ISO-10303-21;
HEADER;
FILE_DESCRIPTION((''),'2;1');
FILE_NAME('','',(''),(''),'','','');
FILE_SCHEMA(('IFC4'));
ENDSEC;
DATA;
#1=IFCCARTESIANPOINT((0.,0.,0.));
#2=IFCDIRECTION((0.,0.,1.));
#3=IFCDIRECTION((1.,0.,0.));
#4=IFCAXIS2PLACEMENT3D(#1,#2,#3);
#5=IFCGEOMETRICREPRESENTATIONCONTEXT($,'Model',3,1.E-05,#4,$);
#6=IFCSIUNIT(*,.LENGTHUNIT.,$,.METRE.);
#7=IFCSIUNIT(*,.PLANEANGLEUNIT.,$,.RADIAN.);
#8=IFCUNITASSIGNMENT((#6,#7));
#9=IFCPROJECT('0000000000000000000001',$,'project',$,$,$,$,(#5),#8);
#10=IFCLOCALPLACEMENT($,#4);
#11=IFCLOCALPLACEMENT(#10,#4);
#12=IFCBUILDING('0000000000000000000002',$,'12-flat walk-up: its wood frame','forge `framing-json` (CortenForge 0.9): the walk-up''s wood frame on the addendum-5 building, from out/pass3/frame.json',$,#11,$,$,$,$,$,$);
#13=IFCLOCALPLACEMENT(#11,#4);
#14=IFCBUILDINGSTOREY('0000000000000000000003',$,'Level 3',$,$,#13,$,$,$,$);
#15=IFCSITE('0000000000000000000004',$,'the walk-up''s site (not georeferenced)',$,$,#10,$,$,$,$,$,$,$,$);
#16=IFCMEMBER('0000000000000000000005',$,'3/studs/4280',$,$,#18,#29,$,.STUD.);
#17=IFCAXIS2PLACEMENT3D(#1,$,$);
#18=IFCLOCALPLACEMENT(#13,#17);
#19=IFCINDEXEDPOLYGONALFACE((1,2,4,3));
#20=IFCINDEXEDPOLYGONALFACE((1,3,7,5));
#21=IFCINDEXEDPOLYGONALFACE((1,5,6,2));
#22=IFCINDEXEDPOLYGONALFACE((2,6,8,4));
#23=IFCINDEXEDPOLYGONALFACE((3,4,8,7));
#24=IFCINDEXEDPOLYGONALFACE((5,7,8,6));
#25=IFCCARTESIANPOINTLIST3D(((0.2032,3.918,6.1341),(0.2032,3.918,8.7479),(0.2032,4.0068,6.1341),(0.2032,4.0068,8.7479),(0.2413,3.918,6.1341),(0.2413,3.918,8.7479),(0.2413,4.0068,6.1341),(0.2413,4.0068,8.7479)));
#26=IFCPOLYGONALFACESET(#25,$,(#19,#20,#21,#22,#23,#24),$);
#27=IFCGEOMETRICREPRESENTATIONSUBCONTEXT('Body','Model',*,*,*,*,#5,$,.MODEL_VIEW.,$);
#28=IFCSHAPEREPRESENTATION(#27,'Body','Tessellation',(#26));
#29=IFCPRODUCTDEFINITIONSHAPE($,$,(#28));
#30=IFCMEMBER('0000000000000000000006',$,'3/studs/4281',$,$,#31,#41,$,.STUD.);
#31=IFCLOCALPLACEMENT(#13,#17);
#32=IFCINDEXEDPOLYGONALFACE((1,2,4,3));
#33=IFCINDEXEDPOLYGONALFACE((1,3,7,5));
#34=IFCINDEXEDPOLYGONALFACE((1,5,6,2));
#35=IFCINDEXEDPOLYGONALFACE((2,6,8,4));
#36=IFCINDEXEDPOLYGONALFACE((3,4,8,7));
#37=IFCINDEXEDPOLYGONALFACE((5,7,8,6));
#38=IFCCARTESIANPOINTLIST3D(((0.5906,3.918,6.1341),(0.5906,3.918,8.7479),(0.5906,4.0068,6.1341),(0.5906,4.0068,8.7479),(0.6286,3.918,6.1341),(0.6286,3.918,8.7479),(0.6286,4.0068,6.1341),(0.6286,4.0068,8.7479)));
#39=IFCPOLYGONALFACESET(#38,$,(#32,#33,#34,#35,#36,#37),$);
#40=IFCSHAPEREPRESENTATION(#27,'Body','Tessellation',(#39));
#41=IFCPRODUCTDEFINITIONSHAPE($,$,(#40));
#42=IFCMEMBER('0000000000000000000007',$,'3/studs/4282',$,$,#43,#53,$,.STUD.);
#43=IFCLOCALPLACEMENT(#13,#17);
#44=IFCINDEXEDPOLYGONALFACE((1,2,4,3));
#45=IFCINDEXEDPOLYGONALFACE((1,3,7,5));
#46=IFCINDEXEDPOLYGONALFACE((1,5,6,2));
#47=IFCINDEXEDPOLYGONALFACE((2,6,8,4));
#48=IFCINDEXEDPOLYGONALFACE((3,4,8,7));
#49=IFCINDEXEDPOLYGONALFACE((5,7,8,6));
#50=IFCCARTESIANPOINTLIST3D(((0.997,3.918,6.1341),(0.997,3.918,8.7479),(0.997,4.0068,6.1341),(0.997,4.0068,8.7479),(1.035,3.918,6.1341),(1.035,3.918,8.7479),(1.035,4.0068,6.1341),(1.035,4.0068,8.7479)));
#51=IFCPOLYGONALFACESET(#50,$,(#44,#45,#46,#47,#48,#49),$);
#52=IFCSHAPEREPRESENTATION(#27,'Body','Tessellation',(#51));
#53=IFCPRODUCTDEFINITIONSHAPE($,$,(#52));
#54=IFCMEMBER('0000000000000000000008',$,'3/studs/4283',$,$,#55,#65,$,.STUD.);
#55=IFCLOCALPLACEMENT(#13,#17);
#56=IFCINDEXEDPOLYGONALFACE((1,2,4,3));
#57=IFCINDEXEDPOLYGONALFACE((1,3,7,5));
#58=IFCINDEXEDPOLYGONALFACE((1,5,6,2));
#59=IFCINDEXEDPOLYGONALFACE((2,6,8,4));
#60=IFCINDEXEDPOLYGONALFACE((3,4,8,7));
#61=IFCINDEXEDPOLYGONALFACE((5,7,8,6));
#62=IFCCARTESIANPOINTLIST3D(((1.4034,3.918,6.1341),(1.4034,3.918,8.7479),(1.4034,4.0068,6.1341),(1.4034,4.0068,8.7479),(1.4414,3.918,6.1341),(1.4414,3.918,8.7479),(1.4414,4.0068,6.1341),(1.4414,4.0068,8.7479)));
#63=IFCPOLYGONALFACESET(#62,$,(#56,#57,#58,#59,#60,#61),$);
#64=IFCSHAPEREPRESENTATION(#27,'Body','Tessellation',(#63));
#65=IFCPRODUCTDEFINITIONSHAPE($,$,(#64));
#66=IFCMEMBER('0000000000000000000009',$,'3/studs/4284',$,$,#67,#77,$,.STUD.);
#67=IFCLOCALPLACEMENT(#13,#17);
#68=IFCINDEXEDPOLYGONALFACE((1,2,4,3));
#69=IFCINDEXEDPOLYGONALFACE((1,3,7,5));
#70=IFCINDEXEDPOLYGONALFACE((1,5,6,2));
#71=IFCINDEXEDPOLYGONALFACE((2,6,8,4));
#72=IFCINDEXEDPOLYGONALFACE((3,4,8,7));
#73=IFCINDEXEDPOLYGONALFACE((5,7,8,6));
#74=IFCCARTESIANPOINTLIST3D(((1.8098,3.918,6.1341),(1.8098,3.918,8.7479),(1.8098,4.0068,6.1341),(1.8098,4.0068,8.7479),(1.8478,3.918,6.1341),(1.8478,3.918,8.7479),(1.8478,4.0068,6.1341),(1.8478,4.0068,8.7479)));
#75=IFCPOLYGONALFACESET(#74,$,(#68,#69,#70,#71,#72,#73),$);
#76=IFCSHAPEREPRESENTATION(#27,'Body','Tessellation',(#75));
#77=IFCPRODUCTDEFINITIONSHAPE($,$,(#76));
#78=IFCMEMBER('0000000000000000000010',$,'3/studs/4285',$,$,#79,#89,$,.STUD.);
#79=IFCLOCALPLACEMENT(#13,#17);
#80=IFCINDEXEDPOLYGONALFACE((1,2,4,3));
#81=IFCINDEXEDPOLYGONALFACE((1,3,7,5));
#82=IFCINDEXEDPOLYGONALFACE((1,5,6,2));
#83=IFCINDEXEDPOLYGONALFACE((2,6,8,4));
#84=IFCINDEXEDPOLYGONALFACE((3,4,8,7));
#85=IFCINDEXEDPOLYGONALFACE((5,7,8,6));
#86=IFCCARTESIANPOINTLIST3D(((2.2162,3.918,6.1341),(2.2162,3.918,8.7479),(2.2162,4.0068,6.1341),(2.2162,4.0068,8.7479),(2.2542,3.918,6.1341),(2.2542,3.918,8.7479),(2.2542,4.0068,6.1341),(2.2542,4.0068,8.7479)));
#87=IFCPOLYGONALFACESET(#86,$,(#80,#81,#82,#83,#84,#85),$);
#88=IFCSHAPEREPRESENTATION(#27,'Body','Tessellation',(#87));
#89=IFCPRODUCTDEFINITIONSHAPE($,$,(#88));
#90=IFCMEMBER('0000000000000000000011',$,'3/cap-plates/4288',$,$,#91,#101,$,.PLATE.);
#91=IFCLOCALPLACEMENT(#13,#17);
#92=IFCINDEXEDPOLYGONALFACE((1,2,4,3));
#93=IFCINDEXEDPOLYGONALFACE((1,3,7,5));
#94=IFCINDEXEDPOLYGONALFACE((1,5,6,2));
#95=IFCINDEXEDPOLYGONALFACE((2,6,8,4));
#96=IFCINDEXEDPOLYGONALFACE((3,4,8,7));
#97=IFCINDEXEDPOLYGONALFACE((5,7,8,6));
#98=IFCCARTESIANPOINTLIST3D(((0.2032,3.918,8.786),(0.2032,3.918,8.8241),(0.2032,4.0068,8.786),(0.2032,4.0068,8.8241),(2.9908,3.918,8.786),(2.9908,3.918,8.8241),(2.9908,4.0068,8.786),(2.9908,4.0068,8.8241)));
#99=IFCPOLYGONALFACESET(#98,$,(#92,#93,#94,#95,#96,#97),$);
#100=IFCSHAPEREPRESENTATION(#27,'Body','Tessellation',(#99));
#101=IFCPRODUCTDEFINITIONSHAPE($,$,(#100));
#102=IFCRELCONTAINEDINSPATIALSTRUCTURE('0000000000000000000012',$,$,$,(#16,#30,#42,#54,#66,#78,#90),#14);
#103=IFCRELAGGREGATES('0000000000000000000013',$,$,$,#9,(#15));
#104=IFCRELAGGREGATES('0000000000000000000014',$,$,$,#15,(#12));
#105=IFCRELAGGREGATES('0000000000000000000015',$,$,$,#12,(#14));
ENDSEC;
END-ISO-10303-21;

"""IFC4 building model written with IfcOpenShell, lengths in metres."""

from ifc_helpers import new_model, si_unit, frame, frame_2d, origin, origin_with_axes, place, context, subcontext, project, spatial, rectangle, extrude, element, save


model = new_model("IFC4")

# Units and contexts
model_context = context("Model", 3, precision=1e-05, world=origin_with_axes())
body_context = subcontext(model_context, "Body", "Model", "MODEL_VIEW")
ifc_project = project(units=[si_unit("LENGTHUNIT", "METRE"), si_unit("PLANEANGLEUNIT", "RADIAN")], contexts=[model_context])

# Site, building, storey
site_placement = place(None, origin_with_axes())
site = spatial("IfcSite", under=ifc_project, at=site_placement, Name="the walk-up's site (not georeferenced)")
building_placement = place(site_placement, origin_with_axes())
building = spatial("IfcBuilding", under=site, at=building_placement, Name="12-flat walk-up: its wood frame", Description="forge `framing-json` (CortenForge 0.9): the walk-up's wood frame on the addendum-5 building, from out/pass3/frame.json")
storey_placement = place(building_placement, origin_with_axes())
storey = spatial("IfcBuildingStorey", under=building, at=storey_placement, Name="Level 3")

# Members
member_1_placement = place(storey_placement, frame((0.2032, 3.9179, 6.1341), z_axis=(0.0, 0.0, 1.0), x_axis=(1.0, 0.0, 0.0)))
element("IfcMember", 1, at=member_1_placement, inside=storey, Name="3/studs/4280", PredefinedType="STUD", context=body_context, shape_type="SweptSolid", body=[
    extrude(rectangle(XDim=0.0381, YDim=0.0889, at=frame_2d((0.019, 0.0445))), origin(), (0.0, 0.0, 1.0), 2.6138),
])
for number, where, z_axis, x_axis, name in (
    (2, (0.5906, 3.9179, 6.1341), (0.0, 0.0, 1.0), (1.0, 0.0, 0.0), "3/studs/4281"),
    (3, (0.997, 3.9179, 6.1341), (0.0, 0.0, 1.0), (1.0, 0.0, 0.0), "3/studs/4282"),
):
    element("IfcMember", number, at=place(storey_placement, frame(where, z_axis=z_axis, x_axis=x_axis)), inside=storey, Name=name, PredefinedType="STUD", context=body_context, shape_type="SweptSolid", body=[
        extrude(rectangle(XDim=0.0381, YDim=0.0889, at=frame_2d((0.0191, 0.0445))), origin(), (0.0, 0.0, 1.0), 2.6138),
    ])
member_2_placement = place(storey_placement, frame((1.4034, 3.9179, 6.1341), z_axis=(0.0, 0.0, 1.0), x_axis=(1.0, 0.0, 0.0)))
element("IfcMember", 4, at=member_2_placement, inside=storey, Name="3/studs/4283", PredefinedType="STUD", context=body_context, shape_type="SweptSolid", body=[
    extrude(rectangle(XDim=0.0381, YDim=0.0889, at=frame_2d((0.019, 0.0445))), origin(), (0.0, 0.0, 1.0), 2.6138),
])
for number, where, z_axis, x_axis, name in (
    (5, (1.8097, 3.9179, 6.1341), (0.0, 0.0, 1.0), (1.0, 0.0, 0.0), "3/studs/4284"),
    (6, (2.2161, 3.9179, 6.1341), (0.0, 0.0, 1.0), (1.0, 0.0, 0.0), "3/studs/4285"),
):
    element("IfcMember", number, at=place(storey_placement, frame(where, z_axis=z_axis, x_axis=x_axis)), inside=storey, Name=name, PredefinedType="STUD", context=body_context, shape_type="SweptSolid", body=[
        extrude(rectangle(XDim=0.0381, YDim=0.0889, at=frame_2d((0.0191, 0.0445))), origin(), (0.0, 0.0, 1.0), 2.6138),
    ])
member_3_placement = place(storey_placement, frame((0.2032, 3.9179, 8.786), z_axis=(0.0, 0.0, 1.0), x_axis=(1.0, 0.0, 0.0)))
element("IfcMember", 7, at=member_3_placement, inside=storey, Name="3/cap-plates/4288", PredefinedType="PLATE", context=body_context, shape_type="SweptSolid", body=[
    extrude(rectangle(XDim=2.7877, YDim=0.0889, at=frame_2d((1.3938, 0.0445))), origin(), (0.0, 0.0, 1.0), 0.0381),
])

save(model, "model.ifc")
